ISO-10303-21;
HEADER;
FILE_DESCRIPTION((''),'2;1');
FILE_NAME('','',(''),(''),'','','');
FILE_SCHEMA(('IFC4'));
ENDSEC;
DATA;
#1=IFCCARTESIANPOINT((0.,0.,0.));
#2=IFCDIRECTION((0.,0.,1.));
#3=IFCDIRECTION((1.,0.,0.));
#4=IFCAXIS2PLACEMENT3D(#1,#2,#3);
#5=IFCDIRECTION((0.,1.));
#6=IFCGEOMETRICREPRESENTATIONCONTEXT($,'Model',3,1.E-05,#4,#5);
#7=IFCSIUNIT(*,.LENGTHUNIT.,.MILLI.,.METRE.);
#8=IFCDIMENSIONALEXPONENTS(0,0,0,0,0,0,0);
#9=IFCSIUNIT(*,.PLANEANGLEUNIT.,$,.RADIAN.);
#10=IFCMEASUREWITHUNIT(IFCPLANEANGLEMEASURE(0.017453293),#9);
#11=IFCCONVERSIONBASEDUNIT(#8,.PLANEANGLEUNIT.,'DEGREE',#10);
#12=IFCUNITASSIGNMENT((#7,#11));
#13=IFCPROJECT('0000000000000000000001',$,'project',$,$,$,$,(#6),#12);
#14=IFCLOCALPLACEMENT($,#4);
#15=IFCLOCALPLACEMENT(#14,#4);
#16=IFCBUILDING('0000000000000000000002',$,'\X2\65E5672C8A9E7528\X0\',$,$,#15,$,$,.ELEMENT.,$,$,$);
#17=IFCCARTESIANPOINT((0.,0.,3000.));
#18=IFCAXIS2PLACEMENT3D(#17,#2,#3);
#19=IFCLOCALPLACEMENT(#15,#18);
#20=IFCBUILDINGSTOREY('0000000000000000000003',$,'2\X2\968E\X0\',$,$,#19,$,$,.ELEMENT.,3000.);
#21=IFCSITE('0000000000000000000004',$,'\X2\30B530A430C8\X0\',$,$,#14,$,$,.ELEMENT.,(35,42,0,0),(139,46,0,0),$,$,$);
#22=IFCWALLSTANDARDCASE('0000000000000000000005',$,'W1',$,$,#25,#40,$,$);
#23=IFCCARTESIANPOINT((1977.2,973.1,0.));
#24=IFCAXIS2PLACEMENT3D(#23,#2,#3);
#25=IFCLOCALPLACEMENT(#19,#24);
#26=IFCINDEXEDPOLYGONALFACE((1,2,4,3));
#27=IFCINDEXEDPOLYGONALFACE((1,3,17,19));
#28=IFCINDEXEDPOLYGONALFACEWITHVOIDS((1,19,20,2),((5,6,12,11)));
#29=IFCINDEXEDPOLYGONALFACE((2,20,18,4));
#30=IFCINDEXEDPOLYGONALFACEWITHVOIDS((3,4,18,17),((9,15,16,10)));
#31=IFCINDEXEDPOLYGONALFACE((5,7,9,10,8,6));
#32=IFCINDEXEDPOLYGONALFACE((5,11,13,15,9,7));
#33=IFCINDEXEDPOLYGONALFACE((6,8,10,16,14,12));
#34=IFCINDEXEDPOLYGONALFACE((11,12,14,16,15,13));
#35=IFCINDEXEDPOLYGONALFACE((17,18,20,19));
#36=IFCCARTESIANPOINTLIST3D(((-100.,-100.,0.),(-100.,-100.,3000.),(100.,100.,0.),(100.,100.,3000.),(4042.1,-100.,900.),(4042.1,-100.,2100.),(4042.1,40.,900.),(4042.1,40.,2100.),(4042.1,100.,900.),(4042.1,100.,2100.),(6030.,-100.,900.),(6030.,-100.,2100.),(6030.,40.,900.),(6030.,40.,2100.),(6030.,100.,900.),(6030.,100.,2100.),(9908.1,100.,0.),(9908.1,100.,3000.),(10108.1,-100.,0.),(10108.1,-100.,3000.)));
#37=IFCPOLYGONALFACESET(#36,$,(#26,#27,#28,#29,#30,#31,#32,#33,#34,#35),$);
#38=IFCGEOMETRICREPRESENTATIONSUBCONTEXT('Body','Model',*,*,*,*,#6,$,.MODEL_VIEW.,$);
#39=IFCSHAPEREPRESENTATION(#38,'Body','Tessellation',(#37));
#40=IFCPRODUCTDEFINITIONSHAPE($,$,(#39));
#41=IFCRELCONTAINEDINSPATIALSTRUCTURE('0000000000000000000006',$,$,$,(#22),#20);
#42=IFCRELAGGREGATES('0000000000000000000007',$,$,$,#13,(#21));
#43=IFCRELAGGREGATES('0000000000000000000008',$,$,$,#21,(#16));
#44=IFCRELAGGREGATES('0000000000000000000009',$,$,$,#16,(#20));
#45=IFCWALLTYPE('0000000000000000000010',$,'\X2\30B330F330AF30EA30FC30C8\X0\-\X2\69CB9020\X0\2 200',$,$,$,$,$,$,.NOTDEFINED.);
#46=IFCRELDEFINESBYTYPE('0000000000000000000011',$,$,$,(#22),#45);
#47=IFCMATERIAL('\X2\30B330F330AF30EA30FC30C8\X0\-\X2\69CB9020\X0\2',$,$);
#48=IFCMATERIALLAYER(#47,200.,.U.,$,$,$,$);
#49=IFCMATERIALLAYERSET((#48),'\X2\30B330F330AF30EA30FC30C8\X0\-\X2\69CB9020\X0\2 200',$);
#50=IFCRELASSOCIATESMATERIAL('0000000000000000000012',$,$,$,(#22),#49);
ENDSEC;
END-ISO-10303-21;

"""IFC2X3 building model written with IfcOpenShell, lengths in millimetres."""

from ifc_helpers import new_model, entity, si_unit, converted_unit, direction, frame, origin_with_axes, origin_2d_with_axis, place, context, subcontext, project, spatial, polyline, rectangle, outline, extrude, material, layer, layer_set, layer_usage, type_object, element, save


model = new_model("IFC2X3")

# Units and contexts
model_context = context("Model", 3, precision=1e-05, world=origin_with_axes(), true_north=direction((0.0, 1.0)))
body_context = subcontext(model_context, "Body", "Model", "MODEL_VIEW")
ifc_project = project(units=[si_unit("LENGTHUNIT", "METRE", prefix="MILLI"), converted_unit("PLANEANGLEUNIT", "DEGREE", entity("IfcPlaneAngleMeasure", 0.017453293), si_unit("PLANEANGLEUNIT", "RADIAN"), dimensions=[0, 0, 0, 0, 0, 0, 0])], contexts=[model_context])

# Site, building, storey
site_placement = place(None, origin_with_axes())
site = spatial("IfcSite", under=ifc_project, at=site_placement, Name="サイト", CompositionType="ELEMENT", RefLatitude=(35, 42, 0, 0), RefLongitude=(139, 46, 0, 0))
building_placement = place(site_placement, origin_with_axes())
building = spatial("IfcBuilding", under=site, at=building_placement, Name="日本語用", CompositionType="ELEMENT")
storey_placement = place(building_placement, frame((0.0, 0.0, 3000.0), z_axis=(0.0, 0.0, 1.0), x_axis=(1.0, 0.0, 0.0)))
storey = spatial("IfcBuildingStorey", under=building, at=storey_placement, Name="2階", CompositionType="ELEMENT", Elevation=3000.0)

# Shared definitions
ifc_material = material(Name="コンクリート-構造2")

# Shared definitions
ifc_layer = layer(ifc_material, 200.0, ventilated="UNKNOWN")
ifc_layer_set = layer_set([ifc_layer], Name="コンクリート-構造2 200")

# Shared definitions
wall_type = type_object("IfcWallType", Name="コンクリート-構造2 200", PredefinedType="NOTDEFINED")

# Wall, opening
ifc_layer_usage_1 = layer_usage(ifc_layer_set, "AXIS2", "NEGATIVE", 100.0)
wall_1_placement = place(storey_placement, frame((1977.2, 973.1, 0.0), z_axis=(0.0, 0.0, 1.0), x_axis=(1.0, 0.0, 0.0)))
wall_1 = element("IfcWallStandardCase", 1, at=wall_1_placement, inside=storey, type_object=wall_type, material=ifc_layer_usage_1, Name="W1", context=body_context, shape_type="SweptSolid", body=[
    extrude(outline(polyline([(-100.0, -100.0), (10108.1, -100.0), (9908.1, 100.0), (100.0, 100.0), (-100.0, -100.0)])), origin_with_axes(), (0.0, 0.0, 1.0), 3000.0),
])
opening_placement = place(wall_1_placement, frame((5036.0, 0.0, 900.0), z_axis=(0.0, 0.0, 1.0), x_axis=(1.0, 0.0, 0.0)))
element("IfcOpeningElement", 2, at=opening_placement, cuts=wall_1, context=body_context, shape_type="SweptSolid", body=[
    extrude(rectangle(XDim=1987.9, YDim=1200.0, at=origin_2d_with_axis()), frame((0.0, 40.0, 600.0), z_axis=(0.0, -1.0, 0.0), x_axis=(1.0, 0.0, 0.0)), (0.0, 0.0, -1.0), 200.0),
    extrude(rectangle(XDim=1987.9, YDim=1200.0, at=origin_2d_with_axis()), frame((0.0, 40.0, 600.0), z_axis=(0.0, 1.0, 0.0), x_axis=(1.0, 0.0, 0.0)), (0.0, 0.0, -1.0), 200.0),
    extrude(rectangle(XDim=2047.9, YDim=1260.0, at=origin_2d_with_axis()), frame((0.0, 240.0, 600.0), z_axis=(0.0, -1.0, 0.0), x_axis=(1.0, 0.0, 0.0)), (0.0, 0.0, -1.0), 400.0),
])

save(model, "model.ifc")
